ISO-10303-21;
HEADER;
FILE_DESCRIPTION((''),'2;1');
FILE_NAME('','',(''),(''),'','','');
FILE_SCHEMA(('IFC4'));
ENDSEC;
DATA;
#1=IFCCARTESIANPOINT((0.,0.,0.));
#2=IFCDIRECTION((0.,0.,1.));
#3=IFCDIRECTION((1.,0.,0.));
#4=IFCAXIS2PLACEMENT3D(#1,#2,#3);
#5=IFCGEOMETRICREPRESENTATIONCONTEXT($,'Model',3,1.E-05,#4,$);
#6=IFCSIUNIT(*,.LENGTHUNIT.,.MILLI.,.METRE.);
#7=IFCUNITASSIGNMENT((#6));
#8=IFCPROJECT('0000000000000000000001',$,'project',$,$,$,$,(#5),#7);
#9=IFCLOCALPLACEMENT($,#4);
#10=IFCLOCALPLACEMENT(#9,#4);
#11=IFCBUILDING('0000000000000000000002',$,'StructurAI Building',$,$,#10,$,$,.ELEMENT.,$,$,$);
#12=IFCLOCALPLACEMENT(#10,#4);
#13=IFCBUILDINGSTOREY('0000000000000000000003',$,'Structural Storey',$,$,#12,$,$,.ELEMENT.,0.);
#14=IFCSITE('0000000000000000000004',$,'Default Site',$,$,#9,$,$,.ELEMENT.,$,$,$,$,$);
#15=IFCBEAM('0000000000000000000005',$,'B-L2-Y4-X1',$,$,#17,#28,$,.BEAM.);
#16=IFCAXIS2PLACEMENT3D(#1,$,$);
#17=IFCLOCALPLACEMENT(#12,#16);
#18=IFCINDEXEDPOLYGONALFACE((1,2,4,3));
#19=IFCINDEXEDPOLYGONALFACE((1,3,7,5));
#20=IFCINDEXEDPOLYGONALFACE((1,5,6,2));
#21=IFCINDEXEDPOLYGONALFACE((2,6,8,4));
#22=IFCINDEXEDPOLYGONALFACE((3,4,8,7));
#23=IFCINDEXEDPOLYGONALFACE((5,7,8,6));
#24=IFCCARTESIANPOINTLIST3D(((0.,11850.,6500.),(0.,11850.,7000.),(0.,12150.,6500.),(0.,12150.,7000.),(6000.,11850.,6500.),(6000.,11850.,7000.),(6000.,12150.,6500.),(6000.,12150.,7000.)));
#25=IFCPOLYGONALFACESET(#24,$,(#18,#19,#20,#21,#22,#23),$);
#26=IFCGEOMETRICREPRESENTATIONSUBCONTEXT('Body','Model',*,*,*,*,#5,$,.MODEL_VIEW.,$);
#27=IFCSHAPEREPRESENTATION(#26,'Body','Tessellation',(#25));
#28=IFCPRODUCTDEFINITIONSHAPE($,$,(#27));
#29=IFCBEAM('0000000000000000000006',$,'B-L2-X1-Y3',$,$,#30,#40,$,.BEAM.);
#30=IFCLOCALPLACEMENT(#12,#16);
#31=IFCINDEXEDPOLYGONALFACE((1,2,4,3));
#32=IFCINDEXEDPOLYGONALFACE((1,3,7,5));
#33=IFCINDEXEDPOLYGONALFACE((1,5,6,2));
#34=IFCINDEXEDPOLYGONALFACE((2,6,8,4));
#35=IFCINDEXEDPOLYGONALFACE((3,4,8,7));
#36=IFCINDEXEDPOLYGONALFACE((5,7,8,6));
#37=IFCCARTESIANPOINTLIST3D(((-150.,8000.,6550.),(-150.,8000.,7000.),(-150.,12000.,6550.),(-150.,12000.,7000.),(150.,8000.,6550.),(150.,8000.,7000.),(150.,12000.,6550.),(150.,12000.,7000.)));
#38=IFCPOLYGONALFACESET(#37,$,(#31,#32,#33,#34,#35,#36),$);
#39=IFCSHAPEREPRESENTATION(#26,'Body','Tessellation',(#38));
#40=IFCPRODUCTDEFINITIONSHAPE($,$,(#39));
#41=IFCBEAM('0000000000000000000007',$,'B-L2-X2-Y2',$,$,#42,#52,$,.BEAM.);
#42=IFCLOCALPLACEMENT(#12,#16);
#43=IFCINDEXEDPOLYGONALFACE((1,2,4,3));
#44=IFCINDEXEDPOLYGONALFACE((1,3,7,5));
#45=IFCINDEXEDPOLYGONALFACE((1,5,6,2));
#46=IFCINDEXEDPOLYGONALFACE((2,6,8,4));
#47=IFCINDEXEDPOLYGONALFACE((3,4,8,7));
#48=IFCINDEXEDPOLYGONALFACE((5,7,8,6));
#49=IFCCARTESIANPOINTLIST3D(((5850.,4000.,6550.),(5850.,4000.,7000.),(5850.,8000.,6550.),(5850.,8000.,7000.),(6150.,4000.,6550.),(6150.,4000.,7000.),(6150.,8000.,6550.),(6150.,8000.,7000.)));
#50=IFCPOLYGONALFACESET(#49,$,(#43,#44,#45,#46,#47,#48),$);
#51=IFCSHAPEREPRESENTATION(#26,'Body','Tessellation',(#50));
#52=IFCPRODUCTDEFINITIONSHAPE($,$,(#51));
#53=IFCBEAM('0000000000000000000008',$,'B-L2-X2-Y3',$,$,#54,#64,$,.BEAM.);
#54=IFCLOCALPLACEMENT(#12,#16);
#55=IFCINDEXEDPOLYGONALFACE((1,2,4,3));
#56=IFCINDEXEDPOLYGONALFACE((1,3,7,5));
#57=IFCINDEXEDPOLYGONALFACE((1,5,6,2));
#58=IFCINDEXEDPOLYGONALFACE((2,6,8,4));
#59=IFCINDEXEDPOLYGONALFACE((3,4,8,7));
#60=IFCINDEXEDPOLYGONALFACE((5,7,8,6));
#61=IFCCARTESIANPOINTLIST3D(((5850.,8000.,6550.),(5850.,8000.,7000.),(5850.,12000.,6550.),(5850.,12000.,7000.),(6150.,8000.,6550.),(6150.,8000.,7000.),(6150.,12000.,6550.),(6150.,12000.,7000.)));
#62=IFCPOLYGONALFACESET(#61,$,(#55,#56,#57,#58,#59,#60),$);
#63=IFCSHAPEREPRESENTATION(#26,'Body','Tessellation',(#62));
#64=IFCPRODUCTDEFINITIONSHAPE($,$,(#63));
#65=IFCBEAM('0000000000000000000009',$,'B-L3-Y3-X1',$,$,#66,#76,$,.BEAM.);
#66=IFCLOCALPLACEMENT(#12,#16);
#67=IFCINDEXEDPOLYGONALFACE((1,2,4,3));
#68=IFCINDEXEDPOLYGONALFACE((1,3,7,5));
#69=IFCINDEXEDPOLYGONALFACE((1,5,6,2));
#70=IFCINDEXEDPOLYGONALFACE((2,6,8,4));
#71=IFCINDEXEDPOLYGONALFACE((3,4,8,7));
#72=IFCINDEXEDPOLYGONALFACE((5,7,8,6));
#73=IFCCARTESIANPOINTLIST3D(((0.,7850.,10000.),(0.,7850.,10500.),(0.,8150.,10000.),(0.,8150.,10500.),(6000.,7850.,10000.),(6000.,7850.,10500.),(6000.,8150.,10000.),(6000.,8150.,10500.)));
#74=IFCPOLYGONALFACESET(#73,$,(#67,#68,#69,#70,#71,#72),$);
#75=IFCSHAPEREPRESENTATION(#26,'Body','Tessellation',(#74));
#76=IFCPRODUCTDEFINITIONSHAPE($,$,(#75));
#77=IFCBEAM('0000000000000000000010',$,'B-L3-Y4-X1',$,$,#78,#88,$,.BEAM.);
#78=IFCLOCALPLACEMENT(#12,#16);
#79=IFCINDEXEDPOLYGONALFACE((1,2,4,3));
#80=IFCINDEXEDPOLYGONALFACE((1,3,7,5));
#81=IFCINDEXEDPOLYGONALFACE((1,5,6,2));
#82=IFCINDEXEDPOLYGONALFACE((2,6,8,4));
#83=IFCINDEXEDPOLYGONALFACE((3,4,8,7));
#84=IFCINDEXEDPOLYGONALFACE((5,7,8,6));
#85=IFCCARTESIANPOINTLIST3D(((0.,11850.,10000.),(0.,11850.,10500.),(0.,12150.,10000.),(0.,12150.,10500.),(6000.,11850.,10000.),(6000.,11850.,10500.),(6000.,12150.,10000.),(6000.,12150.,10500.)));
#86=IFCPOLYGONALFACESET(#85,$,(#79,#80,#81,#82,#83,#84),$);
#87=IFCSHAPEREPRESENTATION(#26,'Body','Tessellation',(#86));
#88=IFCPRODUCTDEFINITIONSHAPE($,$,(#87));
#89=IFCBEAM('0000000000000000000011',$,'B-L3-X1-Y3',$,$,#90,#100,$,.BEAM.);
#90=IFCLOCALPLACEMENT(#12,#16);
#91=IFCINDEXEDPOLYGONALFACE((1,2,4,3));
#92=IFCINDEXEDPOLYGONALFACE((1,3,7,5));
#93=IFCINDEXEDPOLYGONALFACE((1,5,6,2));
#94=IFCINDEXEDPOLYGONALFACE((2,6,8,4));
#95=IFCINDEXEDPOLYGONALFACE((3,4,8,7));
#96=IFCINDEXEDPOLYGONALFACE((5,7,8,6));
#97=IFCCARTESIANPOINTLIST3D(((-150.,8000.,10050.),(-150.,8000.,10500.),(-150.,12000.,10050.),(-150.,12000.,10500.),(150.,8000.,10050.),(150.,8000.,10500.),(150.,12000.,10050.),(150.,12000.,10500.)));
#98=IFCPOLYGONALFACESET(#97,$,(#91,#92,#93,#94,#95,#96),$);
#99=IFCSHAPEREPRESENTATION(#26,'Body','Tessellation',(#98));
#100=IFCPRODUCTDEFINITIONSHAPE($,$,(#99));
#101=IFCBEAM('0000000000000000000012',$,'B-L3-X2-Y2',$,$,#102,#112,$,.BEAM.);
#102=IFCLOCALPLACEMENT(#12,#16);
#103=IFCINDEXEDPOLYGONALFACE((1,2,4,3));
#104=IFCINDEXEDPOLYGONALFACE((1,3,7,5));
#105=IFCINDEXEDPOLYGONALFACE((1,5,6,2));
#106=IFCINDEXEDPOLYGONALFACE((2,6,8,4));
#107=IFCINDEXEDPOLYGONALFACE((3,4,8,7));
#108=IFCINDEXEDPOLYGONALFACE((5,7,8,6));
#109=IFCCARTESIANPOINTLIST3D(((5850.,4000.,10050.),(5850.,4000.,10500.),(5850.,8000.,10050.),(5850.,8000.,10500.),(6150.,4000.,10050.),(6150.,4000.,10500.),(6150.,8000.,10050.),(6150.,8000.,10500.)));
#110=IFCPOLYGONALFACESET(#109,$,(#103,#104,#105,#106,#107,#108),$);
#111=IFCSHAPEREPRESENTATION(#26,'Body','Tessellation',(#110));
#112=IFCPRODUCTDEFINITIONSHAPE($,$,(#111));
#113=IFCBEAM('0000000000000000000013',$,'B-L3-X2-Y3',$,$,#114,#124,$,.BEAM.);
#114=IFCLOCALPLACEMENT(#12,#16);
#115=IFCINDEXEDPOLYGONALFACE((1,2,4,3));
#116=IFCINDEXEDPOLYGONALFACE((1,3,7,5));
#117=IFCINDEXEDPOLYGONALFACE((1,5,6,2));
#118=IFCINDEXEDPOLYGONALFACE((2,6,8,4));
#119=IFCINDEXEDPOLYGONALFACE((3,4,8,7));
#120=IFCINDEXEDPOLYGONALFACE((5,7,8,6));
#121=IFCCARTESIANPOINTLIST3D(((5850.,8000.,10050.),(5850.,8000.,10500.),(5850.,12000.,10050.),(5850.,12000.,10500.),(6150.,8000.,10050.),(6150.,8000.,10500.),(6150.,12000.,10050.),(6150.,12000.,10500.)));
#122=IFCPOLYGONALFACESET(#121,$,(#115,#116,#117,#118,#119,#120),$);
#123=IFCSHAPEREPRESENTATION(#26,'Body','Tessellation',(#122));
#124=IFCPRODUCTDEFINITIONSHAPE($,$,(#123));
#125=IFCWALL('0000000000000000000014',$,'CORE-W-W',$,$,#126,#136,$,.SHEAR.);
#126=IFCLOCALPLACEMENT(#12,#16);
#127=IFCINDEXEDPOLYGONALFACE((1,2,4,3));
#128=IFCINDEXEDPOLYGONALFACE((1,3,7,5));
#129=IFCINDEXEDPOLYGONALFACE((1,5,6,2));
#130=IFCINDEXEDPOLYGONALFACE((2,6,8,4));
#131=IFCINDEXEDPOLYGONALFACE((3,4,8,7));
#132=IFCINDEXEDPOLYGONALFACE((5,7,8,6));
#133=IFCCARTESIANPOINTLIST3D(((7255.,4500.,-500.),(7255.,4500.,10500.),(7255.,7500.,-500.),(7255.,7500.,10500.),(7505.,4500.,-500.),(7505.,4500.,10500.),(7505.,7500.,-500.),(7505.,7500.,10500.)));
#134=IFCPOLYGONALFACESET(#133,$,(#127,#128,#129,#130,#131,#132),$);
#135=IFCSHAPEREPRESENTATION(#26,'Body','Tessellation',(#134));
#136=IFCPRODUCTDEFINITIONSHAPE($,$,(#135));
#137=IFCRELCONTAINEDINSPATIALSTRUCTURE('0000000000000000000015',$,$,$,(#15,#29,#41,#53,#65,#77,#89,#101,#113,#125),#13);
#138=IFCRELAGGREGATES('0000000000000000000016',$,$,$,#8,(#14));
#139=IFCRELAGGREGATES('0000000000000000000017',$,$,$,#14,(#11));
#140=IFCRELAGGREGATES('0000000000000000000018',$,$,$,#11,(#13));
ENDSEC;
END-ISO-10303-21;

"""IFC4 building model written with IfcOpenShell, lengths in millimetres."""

from ifc_helpers import new_model, si_unit, frame, origin_with_axes, place, context, subcontext, project, spatial, rectangle, extrude, element, save


model = new_model("IFC4")

# Units and contexts
model_context = context("Model", 3, precision=1e-05, world=origin_with_axes())
body_context = subcontext(model_context, "Body", "Model", "MODEL_VIEW")
ifc_project = project(units=[si_unit("LENGTHUNIT", "METRE", prefix="MILLI")], contexts=[model_context])

# Site, building, storey
site_placement = place(None, origin_with_axes())
site = spatial("IfcSite", under=ifc_project, at=site_placement, Name="Default Site", CompositionType="ELEMENT")
building_placement = place(site_placement, origin_with_axes())
building = spatial("IfcBuilding", under=site, at=building_placement, Name="StructurAI Building", CompositionType="ELEMENT")
storey_placement = place(building_placement, origin_with_axes())
storey = spatial("IfcBuildingStorey", under=building, at=storey_placement, Name="Structural Storey", CompositionType="ELEMENT", Elevation=0.0)

# Beams
for number, where, z_axis, x_axis, name in (
    (1, (3000.0, 12000.0, 6500.0), (0.0, 0.0, 1.0), (1.0, 0.0, 0.0), "B-L2-Y4-X1"),
):
    element("IfcBeam", number, at=place(storey_placement, frame(where, z_axis=z_axis, x_axis=x_axis)), inside=storey, Name=name, PredefinedType="BEAM", context=body_context, shape_type="SweptSolid", body=[
        extrude(rectangle(XDim=6000.0, YDim=300.0), origin_with_axes(), (0.0, 0.0, 1.0), 500.0),
    ])
for number, where, z_axis, x_axis, name in (
    (2, (0.0, 10000.0, 6550.0), (0.0, 0.0, 1.0), (0.0, 1.0, 0.0), "B-L2-X1-Y3"),
    (3, (6000.0, 6000.0, 6550.0), (0.0, 0.0, 1.0), (0.0, 1.0, 0.0), "B-L2-X2-Y2"),
    (4, (6000.0, 10000.0, 6550.0), (0.0, 0.0, 1.0), (0.0, 1.0, 0.0), "B-L2-X2-Y3"),
):
    element("IfcBeam", number, at=place(storey_placement, frame(where, z_axis=z_axis, x_axis=x_axis)), inside=storey, Name=name, PredefinedType="BEAM", context=body_context, shape_type="SweptSolid", body=[
        extrude(rectangle(XDim=4000.0, YDim=300.0), origin_with_axes(), (0.0, 0.0, 1.0), 450.0),
    ])
for number, where, z_axis, x_axis, name in (
    (5, (3000.0, 8000.0, 10000.0), (0.0, 0.0, 1.0), (1.0, 0.0, 0.0), "B-L3-Y3-X1"),
    (6, (3000.0, 12000.0, 10000.0), (0.0, 0.0, 1.0), (1.0, 0.0, 0.0), "B-L3-Y4-X1"),
):
    element("IfcBeam", number, at=place(storey_placement, frame(where, z_axis=z_axis, x_axis=x_axis)), inside=storey, Name=name, PredefinedType="BEAM", context=body_context, shape_type="SweptSolid", body=[
        extrude(rectangle(XDim=6000.0, YDim=300.0), origin_with_axes(), (0.0, 0.0, 1.0), 500.0),
    ])
for number, where, z_axis, x_axis, name in (
    (7, (0.0, 10000.0, 10050.0), (0.0, 0.0, 1.0), (0.0, 1.0, 0.0), "B-L3-X1-Y3"),
    (8, (6000.0, 6000.0, 10050.0), (0.0, 0.0, 1.0), (0.0, 1.0, 0.0), "B-L3-X2-Y2"),
    (9, (6000.0, 10000.0, 10050.0), (0.0, 0.0, 1.0), (0.0, 1.0, 0.0), "B-L3-X2-Y3"),
):
    element("IfcBeam", number, at=place(storey_placement, frame(where, z_axis=z_axis, x_axis=x_axis)), inside=storey, Name=name, PredefinedType="BEAM", context=body_context, shape_type="SweptSolid", body=[
        extrude(rectangle(XDim=4000.0, YDim=300.0), origin_with_axes(), (0.0, 0.0, 1.0), 450.0),
    ])

# Wall
wall_placement = place(storey_placement, frame((7380.0, 6000.0, -500.0), z_axis=(0.0, 0.0, 1.0), x_axis=(0.0, 1.0, 0.0)))
element("IfcWall", 10, at=wall_placement, inside=storey, Name="CORE-W-W", PredefinedType="SHEAR", context=body_context, shape_type="SweptSolid", body=[
    extrude(rectangle(XDim=3000.0, YDim=250.0), origin_with_axes(), (0.0, 0.0, 1.0), 11000.0),
])

save(model, "model.ifc")
